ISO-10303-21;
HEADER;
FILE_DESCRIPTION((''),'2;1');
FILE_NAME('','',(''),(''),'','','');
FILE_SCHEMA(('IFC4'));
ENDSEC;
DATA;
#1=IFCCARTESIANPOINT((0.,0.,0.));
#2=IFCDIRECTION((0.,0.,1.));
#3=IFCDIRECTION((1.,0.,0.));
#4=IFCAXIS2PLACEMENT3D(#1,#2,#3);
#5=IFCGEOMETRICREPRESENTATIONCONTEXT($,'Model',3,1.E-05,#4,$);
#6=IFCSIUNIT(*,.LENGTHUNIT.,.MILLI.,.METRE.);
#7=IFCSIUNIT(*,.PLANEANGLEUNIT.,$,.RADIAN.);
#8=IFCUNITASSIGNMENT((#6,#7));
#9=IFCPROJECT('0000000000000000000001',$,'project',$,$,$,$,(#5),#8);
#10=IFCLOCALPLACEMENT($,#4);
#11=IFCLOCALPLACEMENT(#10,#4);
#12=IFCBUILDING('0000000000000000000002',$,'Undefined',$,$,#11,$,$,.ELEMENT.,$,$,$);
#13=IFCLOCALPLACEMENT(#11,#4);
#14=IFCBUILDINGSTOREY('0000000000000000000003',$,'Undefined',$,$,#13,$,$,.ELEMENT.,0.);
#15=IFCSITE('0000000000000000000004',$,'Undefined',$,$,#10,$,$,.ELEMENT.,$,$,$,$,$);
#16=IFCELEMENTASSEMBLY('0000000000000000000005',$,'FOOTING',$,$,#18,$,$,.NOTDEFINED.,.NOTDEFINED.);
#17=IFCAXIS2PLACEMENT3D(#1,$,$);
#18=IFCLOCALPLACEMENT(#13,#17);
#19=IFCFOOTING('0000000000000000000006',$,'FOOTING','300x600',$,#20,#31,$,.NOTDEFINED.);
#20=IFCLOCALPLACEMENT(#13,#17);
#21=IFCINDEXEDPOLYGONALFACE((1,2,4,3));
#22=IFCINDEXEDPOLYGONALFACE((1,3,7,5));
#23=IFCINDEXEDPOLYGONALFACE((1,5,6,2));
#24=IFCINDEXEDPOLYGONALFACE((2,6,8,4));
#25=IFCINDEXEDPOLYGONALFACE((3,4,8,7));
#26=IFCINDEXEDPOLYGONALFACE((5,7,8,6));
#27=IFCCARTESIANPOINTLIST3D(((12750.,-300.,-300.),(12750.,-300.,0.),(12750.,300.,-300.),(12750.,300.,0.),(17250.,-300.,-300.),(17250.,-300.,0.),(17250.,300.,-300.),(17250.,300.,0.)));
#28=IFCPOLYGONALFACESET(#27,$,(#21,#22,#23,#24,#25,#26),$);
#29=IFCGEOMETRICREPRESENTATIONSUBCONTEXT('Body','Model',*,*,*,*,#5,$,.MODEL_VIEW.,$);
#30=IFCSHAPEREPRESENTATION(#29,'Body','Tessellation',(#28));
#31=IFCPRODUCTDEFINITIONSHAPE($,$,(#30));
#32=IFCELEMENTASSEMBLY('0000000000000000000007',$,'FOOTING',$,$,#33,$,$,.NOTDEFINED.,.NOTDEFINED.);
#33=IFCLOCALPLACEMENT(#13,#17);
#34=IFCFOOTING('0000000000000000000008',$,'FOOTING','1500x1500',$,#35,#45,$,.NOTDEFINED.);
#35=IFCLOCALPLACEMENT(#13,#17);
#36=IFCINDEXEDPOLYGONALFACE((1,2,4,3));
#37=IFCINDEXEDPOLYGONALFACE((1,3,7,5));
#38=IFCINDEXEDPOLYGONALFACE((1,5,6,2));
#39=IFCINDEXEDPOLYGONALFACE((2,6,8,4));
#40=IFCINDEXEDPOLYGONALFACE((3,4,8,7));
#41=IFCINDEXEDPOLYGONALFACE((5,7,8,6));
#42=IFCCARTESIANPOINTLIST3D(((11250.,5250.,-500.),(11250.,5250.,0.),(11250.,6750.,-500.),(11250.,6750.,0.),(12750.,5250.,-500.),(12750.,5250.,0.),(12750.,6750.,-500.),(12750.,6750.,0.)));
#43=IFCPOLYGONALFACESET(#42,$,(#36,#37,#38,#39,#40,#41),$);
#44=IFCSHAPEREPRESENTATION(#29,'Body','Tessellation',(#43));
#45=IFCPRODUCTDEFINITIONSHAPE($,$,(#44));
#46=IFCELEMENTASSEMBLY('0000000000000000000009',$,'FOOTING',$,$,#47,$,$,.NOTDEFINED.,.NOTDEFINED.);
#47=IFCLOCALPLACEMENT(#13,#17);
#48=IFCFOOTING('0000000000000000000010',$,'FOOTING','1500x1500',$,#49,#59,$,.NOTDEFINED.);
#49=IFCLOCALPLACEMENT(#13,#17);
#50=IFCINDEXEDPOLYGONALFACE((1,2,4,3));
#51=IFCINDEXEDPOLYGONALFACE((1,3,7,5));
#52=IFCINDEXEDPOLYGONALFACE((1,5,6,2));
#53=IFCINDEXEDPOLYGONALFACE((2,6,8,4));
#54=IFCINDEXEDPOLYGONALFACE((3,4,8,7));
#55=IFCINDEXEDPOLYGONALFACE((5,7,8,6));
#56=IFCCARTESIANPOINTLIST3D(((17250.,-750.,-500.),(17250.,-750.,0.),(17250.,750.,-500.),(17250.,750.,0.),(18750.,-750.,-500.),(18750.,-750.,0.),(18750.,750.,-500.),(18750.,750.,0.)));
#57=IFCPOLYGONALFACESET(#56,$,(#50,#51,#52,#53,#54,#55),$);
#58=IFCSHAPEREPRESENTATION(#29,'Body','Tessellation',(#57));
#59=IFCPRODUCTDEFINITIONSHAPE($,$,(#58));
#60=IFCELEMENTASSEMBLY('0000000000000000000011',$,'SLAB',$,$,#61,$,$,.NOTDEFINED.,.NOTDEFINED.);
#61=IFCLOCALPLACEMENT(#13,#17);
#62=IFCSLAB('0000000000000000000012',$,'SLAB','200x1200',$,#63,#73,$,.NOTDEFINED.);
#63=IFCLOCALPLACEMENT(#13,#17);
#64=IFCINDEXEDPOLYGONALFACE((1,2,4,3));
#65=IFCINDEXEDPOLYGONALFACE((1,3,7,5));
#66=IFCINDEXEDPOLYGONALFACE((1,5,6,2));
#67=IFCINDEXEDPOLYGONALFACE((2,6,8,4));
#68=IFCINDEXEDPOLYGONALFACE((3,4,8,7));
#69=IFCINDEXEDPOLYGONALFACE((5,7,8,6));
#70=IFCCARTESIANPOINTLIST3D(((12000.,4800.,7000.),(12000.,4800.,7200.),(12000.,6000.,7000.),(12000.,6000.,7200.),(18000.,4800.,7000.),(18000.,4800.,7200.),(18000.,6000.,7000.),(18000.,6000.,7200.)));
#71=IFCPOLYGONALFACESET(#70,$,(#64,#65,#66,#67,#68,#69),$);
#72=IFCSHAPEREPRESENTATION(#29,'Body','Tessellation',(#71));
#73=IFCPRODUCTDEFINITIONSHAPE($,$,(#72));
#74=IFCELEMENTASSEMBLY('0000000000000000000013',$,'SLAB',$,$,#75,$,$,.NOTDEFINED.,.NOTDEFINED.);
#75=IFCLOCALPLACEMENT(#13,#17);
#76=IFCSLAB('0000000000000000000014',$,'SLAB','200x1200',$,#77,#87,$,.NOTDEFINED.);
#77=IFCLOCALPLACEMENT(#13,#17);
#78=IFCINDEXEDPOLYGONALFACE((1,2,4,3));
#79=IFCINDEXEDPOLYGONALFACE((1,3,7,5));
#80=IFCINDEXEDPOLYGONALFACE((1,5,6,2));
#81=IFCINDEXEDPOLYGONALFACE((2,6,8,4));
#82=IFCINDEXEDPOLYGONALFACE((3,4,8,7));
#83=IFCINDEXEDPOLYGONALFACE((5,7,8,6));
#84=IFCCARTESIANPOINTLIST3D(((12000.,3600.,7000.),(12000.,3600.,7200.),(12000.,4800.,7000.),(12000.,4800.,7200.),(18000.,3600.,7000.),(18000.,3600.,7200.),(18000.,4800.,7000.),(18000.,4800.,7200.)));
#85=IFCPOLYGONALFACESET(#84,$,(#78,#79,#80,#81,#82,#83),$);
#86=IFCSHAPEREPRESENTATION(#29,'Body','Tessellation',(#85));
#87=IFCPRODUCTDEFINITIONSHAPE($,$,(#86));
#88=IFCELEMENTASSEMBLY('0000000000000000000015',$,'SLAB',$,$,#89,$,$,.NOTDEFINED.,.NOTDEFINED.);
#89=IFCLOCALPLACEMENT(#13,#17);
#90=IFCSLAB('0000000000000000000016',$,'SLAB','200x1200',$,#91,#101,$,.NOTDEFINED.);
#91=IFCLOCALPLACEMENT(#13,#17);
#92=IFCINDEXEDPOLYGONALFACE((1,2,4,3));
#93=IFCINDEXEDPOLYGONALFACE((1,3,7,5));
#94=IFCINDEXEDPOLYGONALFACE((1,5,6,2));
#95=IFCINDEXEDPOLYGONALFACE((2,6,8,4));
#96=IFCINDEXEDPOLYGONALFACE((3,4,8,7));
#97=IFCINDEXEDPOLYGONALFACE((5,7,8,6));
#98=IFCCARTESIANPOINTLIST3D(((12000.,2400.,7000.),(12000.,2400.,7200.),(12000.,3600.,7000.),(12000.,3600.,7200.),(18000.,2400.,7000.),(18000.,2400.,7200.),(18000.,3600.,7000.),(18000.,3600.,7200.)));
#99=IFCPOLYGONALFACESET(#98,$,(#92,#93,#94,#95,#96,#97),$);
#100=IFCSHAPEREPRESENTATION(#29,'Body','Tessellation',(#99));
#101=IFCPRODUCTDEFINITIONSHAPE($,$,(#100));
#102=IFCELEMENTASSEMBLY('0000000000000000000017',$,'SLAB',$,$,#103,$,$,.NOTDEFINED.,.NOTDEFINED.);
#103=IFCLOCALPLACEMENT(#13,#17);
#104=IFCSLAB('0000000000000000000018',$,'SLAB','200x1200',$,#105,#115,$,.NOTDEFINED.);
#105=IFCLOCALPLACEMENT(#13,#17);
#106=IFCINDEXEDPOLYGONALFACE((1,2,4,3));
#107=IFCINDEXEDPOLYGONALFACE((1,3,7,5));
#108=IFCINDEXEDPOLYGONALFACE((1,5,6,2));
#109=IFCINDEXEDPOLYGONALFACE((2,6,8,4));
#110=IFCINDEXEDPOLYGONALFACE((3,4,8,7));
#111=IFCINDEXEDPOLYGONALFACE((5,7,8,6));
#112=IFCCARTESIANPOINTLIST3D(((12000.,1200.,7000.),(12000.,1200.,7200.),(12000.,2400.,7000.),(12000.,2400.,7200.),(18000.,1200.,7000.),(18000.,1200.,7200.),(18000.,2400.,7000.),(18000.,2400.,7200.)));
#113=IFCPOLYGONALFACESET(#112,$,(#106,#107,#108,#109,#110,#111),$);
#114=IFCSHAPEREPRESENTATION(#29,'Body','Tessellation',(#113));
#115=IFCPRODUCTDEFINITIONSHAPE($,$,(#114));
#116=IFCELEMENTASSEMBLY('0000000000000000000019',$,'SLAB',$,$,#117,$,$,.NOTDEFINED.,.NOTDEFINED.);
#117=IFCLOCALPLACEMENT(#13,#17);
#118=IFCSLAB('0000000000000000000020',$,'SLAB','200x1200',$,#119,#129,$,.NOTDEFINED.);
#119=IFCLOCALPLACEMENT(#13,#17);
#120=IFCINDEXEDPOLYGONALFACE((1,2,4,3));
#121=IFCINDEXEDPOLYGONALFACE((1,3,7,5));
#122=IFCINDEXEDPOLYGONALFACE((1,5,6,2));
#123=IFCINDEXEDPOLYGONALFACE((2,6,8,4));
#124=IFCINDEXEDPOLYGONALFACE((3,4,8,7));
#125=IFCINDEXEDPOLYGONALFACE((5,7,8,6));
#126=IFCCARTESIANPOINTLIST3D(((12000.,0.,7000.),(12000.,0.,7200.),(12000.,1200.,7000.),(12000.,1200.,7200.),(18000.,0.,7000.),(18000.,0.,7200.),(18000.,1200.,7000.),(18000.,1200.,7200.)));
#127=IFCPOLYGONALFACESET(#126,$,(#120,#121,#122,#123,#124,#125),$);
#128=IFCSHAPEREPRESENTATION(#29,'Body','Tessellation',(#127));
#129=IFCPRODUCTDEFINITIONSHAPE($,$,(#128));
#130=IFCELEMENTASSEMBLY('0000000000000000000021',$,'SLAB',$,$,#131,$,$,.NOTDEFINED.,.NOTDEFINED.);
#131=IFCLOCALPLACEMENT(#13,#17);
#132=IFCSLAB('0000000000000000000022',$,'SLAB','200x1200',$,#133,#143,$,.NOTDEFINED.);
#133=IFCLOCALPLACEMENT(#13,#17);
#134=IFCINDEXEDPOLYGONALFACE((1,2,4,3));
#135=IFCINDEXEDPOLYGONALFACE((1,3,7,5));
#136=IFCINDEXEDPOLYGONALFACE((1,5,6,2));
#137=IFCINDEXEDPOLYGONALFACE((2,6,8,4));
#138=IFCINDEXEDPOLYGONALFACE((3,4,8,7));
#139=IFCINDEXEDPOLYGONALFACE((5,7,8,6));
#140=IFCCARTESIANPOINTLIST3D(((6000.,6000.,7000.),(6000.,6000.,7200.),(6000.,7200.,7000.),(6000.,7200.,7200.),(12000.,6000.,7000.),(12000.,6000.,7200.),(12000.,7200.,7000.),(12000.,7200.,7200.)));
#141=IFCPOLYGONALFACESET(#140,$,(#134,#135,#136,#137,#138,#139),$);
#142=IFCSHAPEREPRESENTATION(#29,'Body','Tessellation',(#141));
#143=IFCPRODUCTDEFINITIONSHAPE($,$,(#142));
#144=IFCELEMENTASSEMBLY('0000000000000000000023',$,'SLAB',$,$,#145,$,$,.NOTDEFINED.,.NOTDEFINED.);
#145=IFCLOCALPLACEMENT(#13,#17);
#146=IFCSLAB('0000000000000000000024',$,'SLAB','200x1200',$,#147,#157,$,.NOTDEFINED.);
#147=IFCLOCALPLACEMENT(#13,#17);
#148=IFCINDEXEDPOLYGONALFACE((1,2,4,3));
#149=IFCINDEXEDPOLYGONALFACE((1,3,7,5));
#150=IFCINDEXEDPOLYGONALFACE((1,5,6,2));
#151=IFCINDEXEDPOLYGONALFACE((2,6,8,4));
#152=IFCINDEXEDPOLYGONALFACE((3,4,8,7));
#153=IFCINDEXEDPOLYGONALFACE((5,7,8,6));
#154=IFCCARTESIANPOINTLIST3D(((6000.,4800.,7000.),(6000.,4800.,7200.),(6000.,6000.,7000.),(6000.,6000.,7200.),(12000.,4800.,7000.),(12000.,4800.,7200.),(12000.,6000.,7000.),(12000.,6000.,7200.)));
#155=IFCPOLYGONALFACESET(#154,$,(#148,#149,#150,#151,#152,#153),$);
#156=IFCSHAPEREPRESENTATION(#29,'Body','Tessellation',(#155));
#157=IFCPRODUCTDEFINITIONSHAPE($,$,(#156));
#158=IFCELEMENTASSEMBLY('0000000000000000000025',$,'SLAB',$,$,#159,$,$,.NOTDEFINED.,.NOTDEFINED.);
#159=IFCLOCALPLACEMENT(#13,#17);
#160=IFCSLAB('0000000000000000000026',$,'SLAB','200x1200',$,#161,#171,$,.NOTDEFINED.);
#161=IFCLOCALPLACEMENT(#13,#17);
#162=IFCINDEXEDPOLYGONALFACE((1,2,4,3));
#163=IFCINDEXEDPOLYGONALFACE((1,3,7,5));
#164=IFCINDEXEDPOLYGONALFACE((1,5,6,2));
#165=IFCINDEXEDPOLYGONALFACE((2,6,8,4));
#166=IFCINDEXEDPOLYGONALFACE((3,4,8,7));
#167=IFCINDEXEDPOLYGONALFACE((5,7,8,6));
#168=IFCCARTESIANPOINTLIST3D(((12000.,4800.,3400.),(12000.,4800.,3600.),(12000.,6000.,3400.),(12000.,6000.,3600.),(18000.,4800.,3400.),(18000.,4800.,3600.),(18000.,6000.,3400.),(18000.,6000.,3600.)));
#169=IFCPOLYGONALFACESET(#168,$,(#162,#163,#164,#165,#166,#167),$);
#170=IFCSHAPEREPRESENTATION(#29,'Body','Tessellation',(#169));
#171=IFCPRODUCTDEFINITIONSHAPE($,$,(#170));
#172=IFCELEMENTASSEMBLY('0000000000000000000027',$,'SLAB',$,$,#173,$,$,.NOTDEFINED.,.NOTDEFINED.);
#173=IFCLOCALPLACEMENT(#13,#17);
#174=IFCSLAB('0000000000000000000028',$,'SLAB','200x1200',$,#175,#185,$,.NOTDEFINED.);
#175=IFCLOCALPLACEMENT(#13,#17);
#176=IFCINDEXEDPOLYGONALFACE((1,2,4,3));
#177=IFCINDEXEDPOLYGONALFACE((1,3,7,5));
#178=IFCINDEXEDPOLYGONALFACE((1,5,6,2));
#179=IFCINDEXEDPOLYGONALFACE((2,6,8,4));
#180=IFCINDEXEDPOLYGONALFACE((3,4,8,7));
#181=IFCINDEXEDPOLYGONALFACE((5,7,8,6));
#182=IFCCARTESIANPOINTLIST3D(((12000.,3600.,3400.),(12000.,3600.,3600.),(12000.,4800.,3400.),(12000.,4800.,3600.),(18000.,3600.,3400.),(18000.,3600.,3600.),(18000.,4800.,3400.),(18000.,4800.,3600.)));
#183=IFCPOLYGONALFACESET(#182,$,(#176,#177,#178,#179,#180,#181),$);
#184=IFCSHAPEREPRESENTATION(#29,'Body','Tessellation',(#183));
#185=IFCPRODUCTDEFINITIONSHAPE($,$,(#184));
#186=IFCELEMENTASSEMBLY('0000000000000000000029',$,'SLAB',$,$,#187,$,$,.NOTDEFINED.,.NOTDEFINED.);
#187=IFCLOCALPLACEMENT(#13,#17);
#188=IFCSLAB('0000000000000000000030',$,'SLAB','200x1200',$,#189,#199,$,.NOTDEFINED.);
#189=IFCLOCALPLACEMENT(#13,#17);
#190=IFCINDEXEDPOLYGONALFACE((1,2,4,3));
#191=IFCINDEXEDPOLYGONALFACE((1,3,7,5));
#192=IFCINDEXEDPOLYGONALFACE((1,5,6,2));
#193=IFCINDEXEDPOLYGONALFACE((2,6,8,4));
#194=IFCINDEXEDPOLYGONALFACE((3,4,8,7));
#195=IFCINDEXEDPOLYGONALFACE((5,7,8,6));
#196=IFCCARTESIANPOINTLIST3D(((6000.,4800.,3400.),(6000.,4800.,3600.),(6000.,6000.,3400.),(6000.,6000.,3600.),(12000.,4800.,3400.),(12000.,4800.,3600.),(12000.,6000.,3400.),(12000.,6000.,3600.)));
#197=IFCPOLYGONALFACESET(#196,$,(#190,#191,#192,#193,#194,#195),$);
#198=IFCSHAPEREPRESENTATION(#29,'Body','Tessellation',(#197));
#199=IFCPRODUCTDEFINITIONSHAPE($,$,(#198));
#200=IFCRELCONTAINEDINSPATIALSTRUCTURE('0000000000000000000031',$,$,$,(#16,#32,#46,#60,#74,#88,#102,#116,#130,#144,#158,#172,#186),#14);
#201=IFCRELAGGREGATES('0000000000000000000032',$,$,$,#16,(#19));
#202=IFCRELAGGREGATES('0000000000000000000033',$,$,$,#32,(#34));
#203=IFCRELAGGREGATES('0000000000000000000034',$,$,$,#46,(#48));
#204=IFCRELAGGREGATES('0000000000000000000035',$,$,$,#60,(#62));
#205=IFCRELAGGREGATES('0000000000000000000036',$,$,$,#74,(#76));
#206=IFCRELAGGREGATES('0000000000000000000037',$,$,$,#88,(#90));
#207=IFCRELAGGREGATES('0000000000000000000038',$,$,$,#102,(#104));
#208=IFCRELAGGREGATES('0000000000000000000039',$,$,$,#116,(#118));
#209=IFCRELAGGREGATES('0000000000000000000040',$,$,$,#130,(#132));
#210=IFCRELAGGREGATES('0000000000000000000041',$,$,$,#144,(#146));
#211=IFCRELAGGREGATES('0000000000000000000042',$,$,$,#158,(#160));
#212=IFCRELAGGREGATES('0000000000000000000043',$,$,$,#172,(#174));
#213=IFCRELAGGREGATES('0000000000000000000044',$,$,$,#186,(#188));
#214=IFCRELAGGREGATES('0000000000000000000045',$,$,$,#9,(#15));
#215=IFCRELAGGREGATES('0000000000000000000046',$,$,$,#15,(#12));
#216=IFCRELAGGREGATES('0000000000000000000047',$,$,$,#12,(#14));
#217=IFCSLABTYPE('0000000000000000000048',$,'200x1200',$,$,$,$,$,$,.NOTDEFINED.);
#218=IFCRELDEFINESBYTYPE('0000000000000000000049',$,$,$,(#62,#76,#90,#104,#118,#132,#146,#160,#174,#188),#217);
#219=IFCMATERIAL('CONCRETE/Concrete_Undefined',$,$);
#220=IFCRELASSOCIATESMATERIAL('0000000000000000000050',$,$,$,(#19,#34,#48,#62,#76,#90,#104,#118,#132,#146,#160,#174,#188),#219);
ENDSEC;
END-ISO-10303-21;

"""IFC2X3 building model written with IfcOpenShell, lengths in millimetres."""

from ifc_helpers import new_model, si_unit, frame, origin_with_axes, origin_2d_with_axis, place, context, subcontext, project, spatial, polyline, rectangle, outline, extrude, material, type_object, element, aggregate, save


model = new_model("IFC2X3")

# Units and contexts
model_context = context("Model", 3, precision=1e-05, world=origin_with_axes())
body_context = subcontext(model_context, "Body", "Model", "MODEL_VIEW")
ifc_project = project(units=[si_unit("LENGTHUNIT", "METRE", prefix="MILLI"), si_unit("PLANEANGLEUNIT", "RADIAN")], contexts=[model_context])

# Site, building, storey
site_placement = place(None, origin_with_axes())
site = spatial("IfcSite", under=ifc_project, at=site_placement, Name="Undefined", CompositionType="ELEMENT")
building_placement = place(site_placement, origin_with_axes())
building = spatial("IfcBuilding", under=site, at=building_placement, Name="Undefined", CompositionType="ELEMENT")
storey_placement = place(building_placement, origin_with_axes())
storey = spatial("IfcBuildingStorey", under=building, at=storey_placement, Name="Undefined", CompositionType="ELEMENT", Elevation=0.0)

# Element assemblies, footings
assembly_1_placement = place(storey_placement, origin_with_axes())
assembly_1 = element("IfcElementAssembly", 1, at=assembly_1_placement, inside=storey, Name="FOOTING", AssemblyPlace="NOTDEFINED", PredefinedType="NOTDEFINED")
ifc_material_1 = material(Name="CONCRETE/Concrete_Undefined")
footing_1_placement = place(assembly_1_placement, frame((12750.0, 0.0, -150.0), z_axis=(0.0, 0.0, 1.0), x_axis=(1.0, 0.0, 0.0)))
footing_1 = element("IfcFooting", 2, at=footing_1_placement, material=ifc_material_1, Name="FOOTING", Description="300x600", PredefinedType="NOTDEFINED", context=body_context, shape_type="SweptSolid", body=[
    extrude(rectangle(XDim=600.0, YDim=300.0, at=origin_2d_with_axis()), frame((4500.0, 0.0, 0.0), z_axis=(-1.0, 0.0, 0.0), x_axis=(0.0, -1.0, 0.0)), (0.0, 0.0, 1.0), 4500.0),
])
aggregate(assembly_1, [footing_1])
assembly_2_placement = place(storey_placement, origin_with_axes())
assembly_2 = element("IfcElementAssembly", 3, at=assembly_2_placement, inside=storey, Name="FOOTING", AssemblyPlace="NOTDEFINED", PredefinedType="NOTDEFINED")
footing_2_placement = place(assembly_2_placement, frame((12000.0, 6000.0, -500.0), z_axis=(0.0, 1.0, 0.0), x_axis=(0.0, 0.0, 1.0)))
footing_2 = element("IfcFooting", 4, at=footing_2_placement, material=ifc_material_1, Name="FOOTING", Description="1500x1500", PredefinedType="NOTDEFINED", context=body_context, shape_type="SweptSolid", body=[
    extrude(rectangle(XDim=1500.0, YDim=1500.0, at=origin_2d_with_axis()), frame((500.0, 0.0, 0.0), z_axis=(-1.0, 0.0, 0.0), x_axis=(0.0, -1.0, 0.0)), (0.0, 0.0, 1.0), 500.0),
])
aggregate(assembly_2, [footing_2])
assembly_3_placement = place(storey_placement, origin_with_axes())
assembly_3 = element("IfcElementAssembly", 5, at=assembly_3_placement, inside=storey, Name="FOOTING", AssemblyPlace="NOTDEFINED", PredefinedType="NOTDEFINED")
footing_3_placement = place(assembly_3_placement, frame((18000.0, 0.0, -500.0), z_axis=(0.0, 1.0, 0.0), x_axis=(0.0, 0.0, 1.0)))
footing_3 = element("IfcFooting", 6, at=footing_3_placement, material=ifc_material_1, Name="FOOTING", Description="1500x1500", PredefinedType="NOTDEFINED", context=body_context, shape_type="SweptSolid", body=[
    extrude(rectangle(XDim=1500.0, YDim=1500.0, at=origin_2d_with_axis()), frame((500.0, 0.0, 0.0), z_axis=(-1.0, 0.0, 0.0), x_axis=(0.0, -1.0, 0.0)), (0.0, 0.0, 1.0), 500.0),
])
aggregate(assembly_3, [footing_3])

# Element assemblies, slabs
assembly_4_placement = place(storey_placement, origin_with_axes())
assembly_4 = element("IfcElementAssembly", 7, at=assembly_4_placement, inside=storey, Name="SLAB", AssemblyPlace="NOTDEFINED", PredefinedType="NOTDEFINED")
slab_type = type_object("IfcSlabType", Name="200x1200", PredefinedType="NOTDEFINED")
slab_1_placement = place(assembly_4_placement, frame((18000.0, 4800.0, 7100.0), z_axis=(0.0, 0.0, 1.0), x_axis=(0.0, 1.0, 0.0)))
slab_1 = element("IfcSlab", 8, at=slab_1_placement, type_object=slab_type, material=ifc_material_1, Name="SLAB", Description="200x1200", PredefinedType="NOTDEFINED", context=body_context, shape_type="SweptSolid", body=[
    extrude(outline(polyline([(0.0, 0.0), (1200.0, 0.0), (1200.0, 6000.0), (0.0, 6000.0), (0.0, 0.0)])), frame((0.0, 0.0, -100.0), z_axis=(0.0, 0.0, 1.0), x_axis=(1.0, 0.0, 0.0)), (0.0, 0.0, 1.0), 200.0),
])
aggregate(assembly_4, [slab_1])
assembly_5_placement = place(storey_placement, origin_with_axes())
assembly_5 = element("IfcElementAssembly", 9, at=assembly_5_placement, inside=storey, Name="SLAB", AssemblyPlace="NOTDEFINED", PredefinedType="NOTDEFINED")
slab_2_placement = place(assembly_5_placement, frame((18000.0, 3600.0, 7100.0), z_axis=(0.0, 0.0, 1.0), x_axis=(0.0, 1.0, 0.0)))
slab_2 = element("IfcSlab", 10, at=slab_2_placement, type_object=slab_type, material=ifc_material_1, Name="SLAB", Description="200x1200", PredefinedType="NOTDEFINED", context=body_context, shape_type="SweptSolid", body=[
    extrude(outline(polyline([(0.0, 0.0), (1200.0, 0.0), (1200.0, 6000.0), (0.0, 6000.0), (0.0, 0.0)])), frame((0.0, 0.0, -100.0), z_axis=(0.0, 0.0, 1.0), x_axis=(1.0, 0.0, 0.0)), (0.0, 0.0, 1.0), 200.0),
])
aggregate(assembly_5, [slab_2])
assembly_6_placement = place(storey_placement, origin_with_axes())
assembly_6 = element("IfcElementAssembly", 11, at=assembly_6_placement, inside=storey, Name="SLAB", AssemblyPlace="NOTDEFINED", PredefinedType="NOTDEFINED")
slab_3_placement = place(assembly_6_placement, frame((18000.0, 2400.0, 7100.0), z_axis=(0.0, 0.0, 1.0), x_axis=(0.0, 1.0, 0.0)))
slab_3 = element("IfcSlab", 12, at=slab_3_placement, type_object=slab_type, material=ifc_material_1, Name="SLAB", Description="200x1200", PredefinedType="NOTDEFINED", context=body_context, shape_type="SweptSolid", body=[
    extrude(outline(polyline([(0.0, 0.0), (1200.0, 0.0), (1200.0, 6000.0), (0.0, 6000.0), (0.0, 0.0)])), frame((0.0, 0.0, -100.0), z_axis=(0.0, 0.0, 1.0), x_axis=(1.0, 0.0, 0.0)), (0.0, 0.0, 1.0), 200.0),
])
aggregate(assembly_6, [slab_3])
assembly_7_placement = place(storey_placement, origin_with_axes())
assembly_7 = element("IfcElementAssembly", 13, at=assembly_7_placement, inside=storey, Name="SLAB", AssemblyPlace="NOTDEFINED", PredefinedType="NOTDEFINED")
slab_4_placement = place(assembly_7_placement, frame((18000.0, 1200.0, 7100.0), z_axis=(0.0, 0.0, 1.0), x_axis=(0.0, 1.0, 0.0)))
slab_4 = element("IfcSlab", 14, at=slab_4_placement, type_object=slab_type, material=ifc_material_1, Name="SLAB", Description="200x1200", PredefinedType="NOTDEFINED", context=body_context, shape_type="SweptSolid", body=[
    extrude(outline(polyline([(0.0, 0.0), (1200.0, 0.0), (1200.0, 6000.0), (0.0, 6000.0), (0.0, 0.0)])), frame((0.0, 0.0, -100.0), z_axis=(0.0, 0.0, 1.0), x_axis=(1.0, 0.0, 0.0)), (0.0, 0.0, 1.0), 200.0),
])
aggregate(assembly_7, [slab_4])
assembly_8_placement = place(storey_placement, origin_with_axes())
assembly_8 = element("IfcElementAssembly", 15, at=assembly_8_placement, inside=storey, Name="SLAB", AssemblyPlace="NOTDEFINED", PredefinedType="NOTDEFINED")
slab_5_placement = place(assembly_8_placement, frame((18000.0, 0.0, 7100.0), z_axis=(0.0, 0.0, 1.0), x_axis=(0.0, 1.0, 0.0)))
slab_5 = element("IfcSlab", 16, at=slab_5_placement, type_object=slab_type, material=ifc_material_1, Name="SLAB", Description="200x1200", PredefinedType="NOTDEFINED", context=body_context, shape_type="SweptSolid", body=[
    extrude(outline(polyline([(0.0, 0.0), (1200.0, 0.0), (1200.0, 6000.0), (0.0, 6000.0), (0.0, 0.0)])), frame((0.0, 0.0, -100.0), z_axis=(0.0, 0.0, 1.0), x_axis=(1.0, 0.0, 0.0)), (0.0, 0.0, 1.0), 200.0),
])
aggregate(assembly_8, [slab_5])
assembly_9_placement = place(storey_placement, origin_with_axes())
assembly_9 = element("IfcElementAssembly", 17, at=assembly_9_placement, inside=storey, Name="SLAB", AssemblyPlace="NOTDEFINED", PredefinedType="NOTDEFINED")
slab_6_placement = place(assembly_9_placement, frame((12000.0, 6000.0, 7100.0), z_axis=(0.0, 0.0, 1.0), x_axis=(0.0, 1.0, 0.0)))
slab_6 = element("IfcSlab", 18, at=slab_6_placement, type_object=slab_type, material=ifc_material_1, Name="SLAB", Description="200x1200", PredefinedType="NOTDEFINED", context=body_context, shape_type="SweptSolid", body=[
    extrude(outline(polyline([(0.0, 0.0), (1200.0, 0.0), (1200.0, 6000.0), (0.0, 6000.0), (0.0, 0.0)])), frame((0.0, 0.0, -100.0), z_axis=(0.0, 0.0, 1.0), x_axis=(1.0, 0.0, 0.0)), (0.0, 0.0, 1.0), 200.0),
])
aggregate(assembly_9, [slab_6])
assembly_10_placement = place(storey_placement, origin_with_axes())
assembly_10 = element("IfcElementAssembly", 19, at=assembly_10_placement, inside=storey, Name="SLAB", AssemblyPlace="NOTDEFINED", PredefinedType="NOTDEFINED")
slab_7_placement = place(assembly_10_placement, frame((12000.0, 4800.0, 7100.0), z_axis=(0.0, 0.0, 1.0), x_axis=(0.0, 1.0, 0.0)))
slab_7 = element("IfcSlab", 20, at=slab_7_placement, type_object=slab_type, material=ifc_material_1, Name="SLAB", Description="200x1200", PredefinedType="NOTDEFINED", context=body_context, shape_type="SweptSolid", body=[
    extrude(outline(polyline([(0.0, 0.0), (1200.0, 0.0), (1200.0, 6000.0), (0.0, 6000.0), (0.0, 0.0)])), frame((0.0, 0.0, -100.0), z_axis=(0.0, 0.0, 1.0), x_axis=(1.0, 0.0, 0.0)), (0.0, 0.0, 1.0), 200.0),
])
aggregate(assembly_10, [slab_7])
assembly_11_placement = place(storey_placement, origin_with_axes())
assembly_11 = element("IfcElementAssembly", 21, at=assembly_11_placement, inside=storey, Name="SLAB", AssemblyPlace="NOTDEFINED", PredefinedType="NOTDEFINED")
slab_8_placement = place(assembly_11_placement, frame((18000.0, 4800.0, 3500.0), z_axis=(0.0, 0.0, 1.0), x_axis=(0.0, 1.0, 0.0)))
slab_8 = element("IfcSlab", 22, at=slab_8_placement, type_object=slab_type, material=ifc_material_1, Name="SLAB", Description="200x1200", PredefinedType="NOTDEFINED", context=body_context, shape_type="SweptSolid", body=[
    extrude(outline(polyline([(0.0, 0.0), (1200.0, 0.0), (1200.0, 6000.0), (0.0, 6000.0), (0.0, 0.0)])), frame((0.0, 0.0, -100.0), z_axis=(0.0, 0.0, 1.0), x_axis=(1.0, 0.0, 0.0)), (0.0, 0.0, 1.0), 200.0),
])
aggregate(assembly_11, [slab_8])
assembly_12_placement = place(storey_placement, origin_with_axes())
assembly_12 = element("IfcElementAssembly", 23, at=assembly_12_placement, inside=storey, Name="SLAB", AssemblyPlace="NOTDEFINED", PredefinedType="NOTDEFINED")
slab_9_placement = place(assembly_12_placement, frame((18000.0, 3600.0, 3500.0), z_axis=(0.0, 0.0, 1.0), x_axis=(0.0, 1.0, 0.0)))
slab_9 = element("IfcSlab", 24, at=slab_9_placement, type_object=slab_type, material=ifc_material_1, Name="SLAB", Description="200x1200", PredefinedType="NOTDEFINED", context=body_context, shape_type="SweptSolid", body=[
    extrude(outline(polyline([(0.0, 0.0), (1200.0, 0.0), (1200.0, 6000.0), (0.0, 6000.0), (0.0, 0.0)])), frame((0.0, 0.0, -100.0), z_axis=(0.0, 0.0, 1.0), x_axis=(1.0, 0.0, 0.0)), (0.0, 0.0, 1.0), 200.0),
])
aggregate(assembly_12, [slab_9])
assembly_13_placement = place(storey_placement, origin_with_axes())
assembly_13 = element("IfcElementAssembly", 25, at=assembly_13_placement, inside=storey, Name="SLAB", AssemblyPlace="NOTDEFINED", PredefinedType="NOTDEFINED")
slab_10_placement = place(assembly_13_placement, frame((12000.0, 4800.0, 3500.0), z_axis=(0.0, 0.0, 1.0), x_axis=(0.0, 1.0, 0.0)))
slab_10 = element("IfcSlab", 26, at=slab_10_placement, type_object=slab_type, material=ifc_material_1, Name="SLAB", Description="200x1200", PredefinedType="NOTDEFINED", context=body_context, shape_type="SweptSolid", body=[
    extrude(outline(polyline([(0.0, 0.0), (1200.0, 0.0), (1200.0, 6000.0), (0.0, 6000.0), (0.0, 0.0)])), frame((0.0, 0.0, -100.0), z_axis=(0.0, 0.0, 1.0), x_axis=(1.0, 0.0, 0.0)), (0.0, 0.0, 1.0), 200.0),
])
aggregate(assembly_13, [slab_10])

save(model, "model.ifc")
